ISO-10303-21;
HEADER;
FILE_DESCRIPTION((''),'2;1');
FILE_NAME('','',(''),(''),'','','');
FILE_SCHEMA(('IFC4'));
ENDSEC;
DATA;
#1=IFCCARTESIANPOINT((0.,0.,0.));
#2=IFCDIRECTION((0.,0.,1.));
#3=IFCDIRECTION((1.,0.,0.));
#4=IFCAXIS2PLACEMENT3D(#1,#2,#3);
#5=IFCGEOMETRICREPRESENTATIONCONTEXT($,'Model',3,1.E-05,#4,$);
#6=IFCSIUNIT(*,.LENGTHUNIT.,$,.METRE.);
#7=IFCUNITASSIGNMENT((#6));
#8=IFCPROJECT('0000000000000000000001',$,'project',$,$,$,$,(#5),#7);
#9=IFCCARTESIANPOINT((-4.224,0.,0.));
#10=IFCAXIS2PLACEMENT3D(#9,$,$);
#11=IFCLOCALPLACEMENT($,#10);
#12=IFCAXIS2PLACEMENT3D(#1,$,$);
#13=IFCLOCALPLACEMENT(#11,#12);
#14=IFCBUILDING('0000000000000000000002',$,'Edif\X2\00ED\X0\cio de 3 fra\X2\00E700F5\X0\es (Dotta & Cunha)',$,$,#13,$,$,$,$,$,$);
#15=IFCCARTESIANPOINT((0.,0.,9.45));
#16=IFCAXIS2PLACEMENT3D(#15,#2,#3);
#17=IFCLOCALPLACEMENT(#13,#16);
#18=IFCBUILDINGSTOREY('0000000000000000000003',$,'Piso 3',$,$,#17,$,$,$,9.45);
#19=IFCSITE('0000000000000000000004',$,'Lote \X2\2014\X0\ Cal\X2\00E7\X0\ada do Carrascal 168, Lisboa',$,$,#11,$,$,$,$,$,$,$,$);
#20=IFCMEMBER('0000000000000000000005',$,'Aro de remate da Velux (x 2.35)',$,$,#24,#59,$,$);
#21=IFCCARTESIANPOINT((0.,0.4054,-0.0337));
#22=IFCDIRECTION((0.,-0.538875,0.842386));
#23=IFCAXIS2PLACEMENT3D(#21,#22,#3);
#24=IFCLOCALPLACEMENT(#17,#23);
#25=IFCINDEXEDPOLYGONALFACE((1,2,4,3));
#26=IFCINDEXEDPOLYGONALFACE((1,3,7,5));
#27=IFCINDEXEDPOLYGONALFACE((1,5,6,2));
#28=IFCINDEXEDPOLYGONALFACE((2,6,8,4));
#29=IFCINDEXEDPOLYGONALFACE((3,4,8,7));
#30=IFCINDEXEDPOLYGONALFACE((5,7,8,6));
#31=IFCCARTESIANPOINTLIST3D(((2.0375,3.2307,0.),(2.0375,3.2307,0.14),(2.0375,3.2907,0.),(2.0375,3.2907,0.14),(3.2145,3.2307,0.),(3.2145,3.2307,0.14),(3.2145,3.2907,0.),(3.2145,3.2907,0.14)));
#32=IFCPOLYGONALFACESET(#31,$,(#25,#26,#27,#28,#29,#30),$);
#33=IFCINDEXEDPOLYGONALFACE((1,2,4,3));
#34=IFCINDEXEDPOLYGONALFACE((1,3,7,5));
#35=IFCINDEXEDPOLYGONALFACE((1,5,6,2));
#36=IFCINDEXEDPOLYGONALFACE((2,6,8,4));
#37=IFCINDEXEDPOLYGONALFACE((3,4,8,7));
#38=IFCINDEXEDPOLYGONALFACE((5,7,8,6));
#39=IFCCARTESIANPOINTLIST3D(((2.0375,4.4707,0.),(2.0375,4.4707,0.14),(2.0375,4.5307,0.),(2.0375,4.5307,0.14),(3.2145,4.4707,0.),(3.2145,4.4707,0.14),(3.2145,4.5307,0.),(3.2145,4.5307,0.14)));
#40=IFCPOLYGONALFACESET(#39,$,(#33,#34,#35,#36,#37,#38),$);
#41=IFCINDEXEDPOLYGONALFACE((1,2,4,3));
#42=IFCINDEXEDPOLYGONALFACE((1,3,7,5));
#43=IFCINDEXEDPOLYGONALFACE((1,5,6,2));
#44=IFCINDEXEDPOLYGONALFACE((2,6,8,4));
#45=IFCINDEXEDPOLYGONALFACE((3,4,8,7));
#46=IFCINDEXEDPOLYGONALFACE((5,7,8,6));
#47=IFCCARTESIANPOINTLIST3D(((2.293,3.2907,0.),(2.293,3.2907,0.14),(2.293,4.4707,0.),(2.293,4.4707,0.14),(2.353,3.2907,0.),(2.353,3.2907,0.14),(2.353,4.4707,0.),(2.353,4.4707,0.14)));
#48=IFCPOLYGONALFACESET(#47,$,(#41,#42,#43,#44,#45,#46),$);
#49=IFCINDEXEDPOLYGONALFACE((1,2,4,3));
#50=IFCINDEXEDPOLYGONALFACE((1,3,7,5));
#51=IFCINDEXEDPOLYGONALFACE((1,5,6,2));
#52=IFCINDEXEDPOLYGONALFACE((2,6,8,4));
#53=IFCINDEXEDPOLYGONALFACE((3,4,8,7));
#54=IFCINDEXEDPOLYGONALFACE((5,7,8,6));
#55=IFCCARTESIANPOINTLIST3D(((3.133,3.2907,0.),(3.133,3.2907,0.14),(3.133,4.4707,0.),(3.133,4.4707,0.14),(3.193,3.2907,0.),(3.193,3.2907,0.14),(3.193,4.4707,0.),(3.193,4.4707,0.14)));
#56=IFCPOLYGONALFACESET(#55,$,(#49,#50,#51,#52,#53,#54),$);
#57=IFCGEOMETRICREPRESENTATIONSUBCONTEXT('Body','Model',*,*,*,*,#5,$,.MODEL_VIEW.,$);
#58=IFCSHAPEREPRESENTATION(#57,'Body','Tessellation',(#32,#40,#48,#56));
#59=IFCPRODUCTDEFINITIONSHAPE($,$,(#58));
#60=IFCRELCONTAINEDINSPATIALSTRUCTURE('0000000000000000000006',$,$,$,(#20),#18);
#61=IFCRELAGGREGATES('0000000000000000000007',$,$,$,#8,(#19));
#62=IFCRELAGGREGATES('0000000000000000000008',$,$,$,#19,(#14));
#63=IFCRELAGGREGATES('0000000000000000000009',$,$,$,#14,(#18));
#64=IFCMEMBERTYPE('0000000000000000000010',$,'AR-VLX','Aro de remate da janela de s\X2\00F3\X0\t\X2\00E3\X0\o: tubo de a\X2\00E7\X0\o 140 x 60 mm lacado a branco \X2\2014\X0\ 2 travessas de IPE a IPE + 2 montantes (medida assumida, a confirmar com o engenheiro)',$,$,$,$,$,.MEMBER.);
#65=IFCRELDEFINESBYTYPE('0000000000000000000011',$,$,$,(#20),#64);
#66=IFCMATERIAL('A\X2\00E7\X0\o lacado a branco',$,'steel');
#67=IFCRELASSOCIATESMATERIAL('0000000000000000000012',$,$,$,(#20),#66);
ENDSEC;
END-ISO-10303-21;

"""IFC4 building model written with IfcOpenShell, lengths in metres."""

from ifc_helpers import new_model, si_unit, frame, origin, origin_with_axes, place, context, subcontext, project, spatial, line, indexed_curve, outline, extrude, material, type_object, element, save


model = new_model("IFC4")

# Units and contexts
model_context = context("Model", 3, precision=1e-05, world=origin_with_axes())
body_context = subcontext(model_context, "Body", "Model", "MODEL_VIEW")
ifc_project = project(units=[si_unit("LENGTHUNIT", "METRE")], contexts=[model_context])

# Site, building, storey
site_placement = place(None, frame((-4.224, 0.0, 0.0)))
site = spatial("IfcSite", under=ifc_project, at=site_placement, Name="Lote — Calçada do Carrascal 168, Lisboa")
building_placement = place(site_placement, origin())
building = spatial("IfcBuilding", under=site, at=building_placement, Name="Edifício de 3 frações (Dotta & Cunha)")
storey_placement = place(building_placement, frame((0.0, 0.0, 9.45), z_axis=(0.0, 0.0, 1.0), x_axis=(1.0, 0.0, 0.0)))
storey = spatial("IfcBuildingStorey", under=building, at=storey_placement, Name="Piso 3", Elevation=9.45)

# Member
ifc_material_1 = material(Name="Aço lacado a branco", Category="steel")
member_type = type_object("IfcMemberType", Name="AR-VLX", Description="Aro de remate da janela de sótão: tubo de aço 140 x 60 mm lacado a branco — 2 travessas de IPE a IPE + 2 montantes (medida assumida, a confirmar com o engenheiro)", PredefinedType="MEMBER")
member_placement = place(storey_placement, frame((0.0, 0.4054, -0.0337), z_axis=(0.0, -0.538875, 0.842386), x_axis=(1.0, 0.0, 0.0)))
element("IfcMember", 1, at=member_placement, inside=storey, type_object=member_type, material=ifc_material_1, Name="Aro de remate da Velux (x 2.35)", context=body_context, shape_type="SweptSolid", body=[
    extrude(outline(indexed_curve([(3.2145, 3.2307), (2.0375, 3.2307), (2.0375, 3.2907), (3.2145, 3.2907)], segments=[line(1, 2, 3, 4, 1)])), origin_with_axes(), (0.0, 0.0, 1.0), 0.14),
    extrude(outline(indexed_curve([(3.2145, 4.4707), (2.0375, 4.4707), (2.0375, 4.5307), (3.2145, 4.5307)], segments=[line(1, 2, 3, 4, 1)])), origin_with_axes(), (0.0, 0.0, 1.0), 0.14),
    extrude(outline(indexed_curve([(2.293, 3.2907), (2.293, 4.4707), (2.353, 4.4707), (2.353, 3.2907)], segments=[line(1, 2, 3, 4, 1)])), origin_with_axes(), (0.0, 0.0, 1.0), 0.14),
    extrude(outline(indexed_curve([(3.133, 3.2907), (3.133, 4.4707), (3.193, 4.4707), (3.193, 3.2907)], segments=[line(1, 2, 3, 4, 1)])), origin_with_axes(), (0.0, 0.0, 1.0), 0.14),
])

save(model, "model.ifc")
